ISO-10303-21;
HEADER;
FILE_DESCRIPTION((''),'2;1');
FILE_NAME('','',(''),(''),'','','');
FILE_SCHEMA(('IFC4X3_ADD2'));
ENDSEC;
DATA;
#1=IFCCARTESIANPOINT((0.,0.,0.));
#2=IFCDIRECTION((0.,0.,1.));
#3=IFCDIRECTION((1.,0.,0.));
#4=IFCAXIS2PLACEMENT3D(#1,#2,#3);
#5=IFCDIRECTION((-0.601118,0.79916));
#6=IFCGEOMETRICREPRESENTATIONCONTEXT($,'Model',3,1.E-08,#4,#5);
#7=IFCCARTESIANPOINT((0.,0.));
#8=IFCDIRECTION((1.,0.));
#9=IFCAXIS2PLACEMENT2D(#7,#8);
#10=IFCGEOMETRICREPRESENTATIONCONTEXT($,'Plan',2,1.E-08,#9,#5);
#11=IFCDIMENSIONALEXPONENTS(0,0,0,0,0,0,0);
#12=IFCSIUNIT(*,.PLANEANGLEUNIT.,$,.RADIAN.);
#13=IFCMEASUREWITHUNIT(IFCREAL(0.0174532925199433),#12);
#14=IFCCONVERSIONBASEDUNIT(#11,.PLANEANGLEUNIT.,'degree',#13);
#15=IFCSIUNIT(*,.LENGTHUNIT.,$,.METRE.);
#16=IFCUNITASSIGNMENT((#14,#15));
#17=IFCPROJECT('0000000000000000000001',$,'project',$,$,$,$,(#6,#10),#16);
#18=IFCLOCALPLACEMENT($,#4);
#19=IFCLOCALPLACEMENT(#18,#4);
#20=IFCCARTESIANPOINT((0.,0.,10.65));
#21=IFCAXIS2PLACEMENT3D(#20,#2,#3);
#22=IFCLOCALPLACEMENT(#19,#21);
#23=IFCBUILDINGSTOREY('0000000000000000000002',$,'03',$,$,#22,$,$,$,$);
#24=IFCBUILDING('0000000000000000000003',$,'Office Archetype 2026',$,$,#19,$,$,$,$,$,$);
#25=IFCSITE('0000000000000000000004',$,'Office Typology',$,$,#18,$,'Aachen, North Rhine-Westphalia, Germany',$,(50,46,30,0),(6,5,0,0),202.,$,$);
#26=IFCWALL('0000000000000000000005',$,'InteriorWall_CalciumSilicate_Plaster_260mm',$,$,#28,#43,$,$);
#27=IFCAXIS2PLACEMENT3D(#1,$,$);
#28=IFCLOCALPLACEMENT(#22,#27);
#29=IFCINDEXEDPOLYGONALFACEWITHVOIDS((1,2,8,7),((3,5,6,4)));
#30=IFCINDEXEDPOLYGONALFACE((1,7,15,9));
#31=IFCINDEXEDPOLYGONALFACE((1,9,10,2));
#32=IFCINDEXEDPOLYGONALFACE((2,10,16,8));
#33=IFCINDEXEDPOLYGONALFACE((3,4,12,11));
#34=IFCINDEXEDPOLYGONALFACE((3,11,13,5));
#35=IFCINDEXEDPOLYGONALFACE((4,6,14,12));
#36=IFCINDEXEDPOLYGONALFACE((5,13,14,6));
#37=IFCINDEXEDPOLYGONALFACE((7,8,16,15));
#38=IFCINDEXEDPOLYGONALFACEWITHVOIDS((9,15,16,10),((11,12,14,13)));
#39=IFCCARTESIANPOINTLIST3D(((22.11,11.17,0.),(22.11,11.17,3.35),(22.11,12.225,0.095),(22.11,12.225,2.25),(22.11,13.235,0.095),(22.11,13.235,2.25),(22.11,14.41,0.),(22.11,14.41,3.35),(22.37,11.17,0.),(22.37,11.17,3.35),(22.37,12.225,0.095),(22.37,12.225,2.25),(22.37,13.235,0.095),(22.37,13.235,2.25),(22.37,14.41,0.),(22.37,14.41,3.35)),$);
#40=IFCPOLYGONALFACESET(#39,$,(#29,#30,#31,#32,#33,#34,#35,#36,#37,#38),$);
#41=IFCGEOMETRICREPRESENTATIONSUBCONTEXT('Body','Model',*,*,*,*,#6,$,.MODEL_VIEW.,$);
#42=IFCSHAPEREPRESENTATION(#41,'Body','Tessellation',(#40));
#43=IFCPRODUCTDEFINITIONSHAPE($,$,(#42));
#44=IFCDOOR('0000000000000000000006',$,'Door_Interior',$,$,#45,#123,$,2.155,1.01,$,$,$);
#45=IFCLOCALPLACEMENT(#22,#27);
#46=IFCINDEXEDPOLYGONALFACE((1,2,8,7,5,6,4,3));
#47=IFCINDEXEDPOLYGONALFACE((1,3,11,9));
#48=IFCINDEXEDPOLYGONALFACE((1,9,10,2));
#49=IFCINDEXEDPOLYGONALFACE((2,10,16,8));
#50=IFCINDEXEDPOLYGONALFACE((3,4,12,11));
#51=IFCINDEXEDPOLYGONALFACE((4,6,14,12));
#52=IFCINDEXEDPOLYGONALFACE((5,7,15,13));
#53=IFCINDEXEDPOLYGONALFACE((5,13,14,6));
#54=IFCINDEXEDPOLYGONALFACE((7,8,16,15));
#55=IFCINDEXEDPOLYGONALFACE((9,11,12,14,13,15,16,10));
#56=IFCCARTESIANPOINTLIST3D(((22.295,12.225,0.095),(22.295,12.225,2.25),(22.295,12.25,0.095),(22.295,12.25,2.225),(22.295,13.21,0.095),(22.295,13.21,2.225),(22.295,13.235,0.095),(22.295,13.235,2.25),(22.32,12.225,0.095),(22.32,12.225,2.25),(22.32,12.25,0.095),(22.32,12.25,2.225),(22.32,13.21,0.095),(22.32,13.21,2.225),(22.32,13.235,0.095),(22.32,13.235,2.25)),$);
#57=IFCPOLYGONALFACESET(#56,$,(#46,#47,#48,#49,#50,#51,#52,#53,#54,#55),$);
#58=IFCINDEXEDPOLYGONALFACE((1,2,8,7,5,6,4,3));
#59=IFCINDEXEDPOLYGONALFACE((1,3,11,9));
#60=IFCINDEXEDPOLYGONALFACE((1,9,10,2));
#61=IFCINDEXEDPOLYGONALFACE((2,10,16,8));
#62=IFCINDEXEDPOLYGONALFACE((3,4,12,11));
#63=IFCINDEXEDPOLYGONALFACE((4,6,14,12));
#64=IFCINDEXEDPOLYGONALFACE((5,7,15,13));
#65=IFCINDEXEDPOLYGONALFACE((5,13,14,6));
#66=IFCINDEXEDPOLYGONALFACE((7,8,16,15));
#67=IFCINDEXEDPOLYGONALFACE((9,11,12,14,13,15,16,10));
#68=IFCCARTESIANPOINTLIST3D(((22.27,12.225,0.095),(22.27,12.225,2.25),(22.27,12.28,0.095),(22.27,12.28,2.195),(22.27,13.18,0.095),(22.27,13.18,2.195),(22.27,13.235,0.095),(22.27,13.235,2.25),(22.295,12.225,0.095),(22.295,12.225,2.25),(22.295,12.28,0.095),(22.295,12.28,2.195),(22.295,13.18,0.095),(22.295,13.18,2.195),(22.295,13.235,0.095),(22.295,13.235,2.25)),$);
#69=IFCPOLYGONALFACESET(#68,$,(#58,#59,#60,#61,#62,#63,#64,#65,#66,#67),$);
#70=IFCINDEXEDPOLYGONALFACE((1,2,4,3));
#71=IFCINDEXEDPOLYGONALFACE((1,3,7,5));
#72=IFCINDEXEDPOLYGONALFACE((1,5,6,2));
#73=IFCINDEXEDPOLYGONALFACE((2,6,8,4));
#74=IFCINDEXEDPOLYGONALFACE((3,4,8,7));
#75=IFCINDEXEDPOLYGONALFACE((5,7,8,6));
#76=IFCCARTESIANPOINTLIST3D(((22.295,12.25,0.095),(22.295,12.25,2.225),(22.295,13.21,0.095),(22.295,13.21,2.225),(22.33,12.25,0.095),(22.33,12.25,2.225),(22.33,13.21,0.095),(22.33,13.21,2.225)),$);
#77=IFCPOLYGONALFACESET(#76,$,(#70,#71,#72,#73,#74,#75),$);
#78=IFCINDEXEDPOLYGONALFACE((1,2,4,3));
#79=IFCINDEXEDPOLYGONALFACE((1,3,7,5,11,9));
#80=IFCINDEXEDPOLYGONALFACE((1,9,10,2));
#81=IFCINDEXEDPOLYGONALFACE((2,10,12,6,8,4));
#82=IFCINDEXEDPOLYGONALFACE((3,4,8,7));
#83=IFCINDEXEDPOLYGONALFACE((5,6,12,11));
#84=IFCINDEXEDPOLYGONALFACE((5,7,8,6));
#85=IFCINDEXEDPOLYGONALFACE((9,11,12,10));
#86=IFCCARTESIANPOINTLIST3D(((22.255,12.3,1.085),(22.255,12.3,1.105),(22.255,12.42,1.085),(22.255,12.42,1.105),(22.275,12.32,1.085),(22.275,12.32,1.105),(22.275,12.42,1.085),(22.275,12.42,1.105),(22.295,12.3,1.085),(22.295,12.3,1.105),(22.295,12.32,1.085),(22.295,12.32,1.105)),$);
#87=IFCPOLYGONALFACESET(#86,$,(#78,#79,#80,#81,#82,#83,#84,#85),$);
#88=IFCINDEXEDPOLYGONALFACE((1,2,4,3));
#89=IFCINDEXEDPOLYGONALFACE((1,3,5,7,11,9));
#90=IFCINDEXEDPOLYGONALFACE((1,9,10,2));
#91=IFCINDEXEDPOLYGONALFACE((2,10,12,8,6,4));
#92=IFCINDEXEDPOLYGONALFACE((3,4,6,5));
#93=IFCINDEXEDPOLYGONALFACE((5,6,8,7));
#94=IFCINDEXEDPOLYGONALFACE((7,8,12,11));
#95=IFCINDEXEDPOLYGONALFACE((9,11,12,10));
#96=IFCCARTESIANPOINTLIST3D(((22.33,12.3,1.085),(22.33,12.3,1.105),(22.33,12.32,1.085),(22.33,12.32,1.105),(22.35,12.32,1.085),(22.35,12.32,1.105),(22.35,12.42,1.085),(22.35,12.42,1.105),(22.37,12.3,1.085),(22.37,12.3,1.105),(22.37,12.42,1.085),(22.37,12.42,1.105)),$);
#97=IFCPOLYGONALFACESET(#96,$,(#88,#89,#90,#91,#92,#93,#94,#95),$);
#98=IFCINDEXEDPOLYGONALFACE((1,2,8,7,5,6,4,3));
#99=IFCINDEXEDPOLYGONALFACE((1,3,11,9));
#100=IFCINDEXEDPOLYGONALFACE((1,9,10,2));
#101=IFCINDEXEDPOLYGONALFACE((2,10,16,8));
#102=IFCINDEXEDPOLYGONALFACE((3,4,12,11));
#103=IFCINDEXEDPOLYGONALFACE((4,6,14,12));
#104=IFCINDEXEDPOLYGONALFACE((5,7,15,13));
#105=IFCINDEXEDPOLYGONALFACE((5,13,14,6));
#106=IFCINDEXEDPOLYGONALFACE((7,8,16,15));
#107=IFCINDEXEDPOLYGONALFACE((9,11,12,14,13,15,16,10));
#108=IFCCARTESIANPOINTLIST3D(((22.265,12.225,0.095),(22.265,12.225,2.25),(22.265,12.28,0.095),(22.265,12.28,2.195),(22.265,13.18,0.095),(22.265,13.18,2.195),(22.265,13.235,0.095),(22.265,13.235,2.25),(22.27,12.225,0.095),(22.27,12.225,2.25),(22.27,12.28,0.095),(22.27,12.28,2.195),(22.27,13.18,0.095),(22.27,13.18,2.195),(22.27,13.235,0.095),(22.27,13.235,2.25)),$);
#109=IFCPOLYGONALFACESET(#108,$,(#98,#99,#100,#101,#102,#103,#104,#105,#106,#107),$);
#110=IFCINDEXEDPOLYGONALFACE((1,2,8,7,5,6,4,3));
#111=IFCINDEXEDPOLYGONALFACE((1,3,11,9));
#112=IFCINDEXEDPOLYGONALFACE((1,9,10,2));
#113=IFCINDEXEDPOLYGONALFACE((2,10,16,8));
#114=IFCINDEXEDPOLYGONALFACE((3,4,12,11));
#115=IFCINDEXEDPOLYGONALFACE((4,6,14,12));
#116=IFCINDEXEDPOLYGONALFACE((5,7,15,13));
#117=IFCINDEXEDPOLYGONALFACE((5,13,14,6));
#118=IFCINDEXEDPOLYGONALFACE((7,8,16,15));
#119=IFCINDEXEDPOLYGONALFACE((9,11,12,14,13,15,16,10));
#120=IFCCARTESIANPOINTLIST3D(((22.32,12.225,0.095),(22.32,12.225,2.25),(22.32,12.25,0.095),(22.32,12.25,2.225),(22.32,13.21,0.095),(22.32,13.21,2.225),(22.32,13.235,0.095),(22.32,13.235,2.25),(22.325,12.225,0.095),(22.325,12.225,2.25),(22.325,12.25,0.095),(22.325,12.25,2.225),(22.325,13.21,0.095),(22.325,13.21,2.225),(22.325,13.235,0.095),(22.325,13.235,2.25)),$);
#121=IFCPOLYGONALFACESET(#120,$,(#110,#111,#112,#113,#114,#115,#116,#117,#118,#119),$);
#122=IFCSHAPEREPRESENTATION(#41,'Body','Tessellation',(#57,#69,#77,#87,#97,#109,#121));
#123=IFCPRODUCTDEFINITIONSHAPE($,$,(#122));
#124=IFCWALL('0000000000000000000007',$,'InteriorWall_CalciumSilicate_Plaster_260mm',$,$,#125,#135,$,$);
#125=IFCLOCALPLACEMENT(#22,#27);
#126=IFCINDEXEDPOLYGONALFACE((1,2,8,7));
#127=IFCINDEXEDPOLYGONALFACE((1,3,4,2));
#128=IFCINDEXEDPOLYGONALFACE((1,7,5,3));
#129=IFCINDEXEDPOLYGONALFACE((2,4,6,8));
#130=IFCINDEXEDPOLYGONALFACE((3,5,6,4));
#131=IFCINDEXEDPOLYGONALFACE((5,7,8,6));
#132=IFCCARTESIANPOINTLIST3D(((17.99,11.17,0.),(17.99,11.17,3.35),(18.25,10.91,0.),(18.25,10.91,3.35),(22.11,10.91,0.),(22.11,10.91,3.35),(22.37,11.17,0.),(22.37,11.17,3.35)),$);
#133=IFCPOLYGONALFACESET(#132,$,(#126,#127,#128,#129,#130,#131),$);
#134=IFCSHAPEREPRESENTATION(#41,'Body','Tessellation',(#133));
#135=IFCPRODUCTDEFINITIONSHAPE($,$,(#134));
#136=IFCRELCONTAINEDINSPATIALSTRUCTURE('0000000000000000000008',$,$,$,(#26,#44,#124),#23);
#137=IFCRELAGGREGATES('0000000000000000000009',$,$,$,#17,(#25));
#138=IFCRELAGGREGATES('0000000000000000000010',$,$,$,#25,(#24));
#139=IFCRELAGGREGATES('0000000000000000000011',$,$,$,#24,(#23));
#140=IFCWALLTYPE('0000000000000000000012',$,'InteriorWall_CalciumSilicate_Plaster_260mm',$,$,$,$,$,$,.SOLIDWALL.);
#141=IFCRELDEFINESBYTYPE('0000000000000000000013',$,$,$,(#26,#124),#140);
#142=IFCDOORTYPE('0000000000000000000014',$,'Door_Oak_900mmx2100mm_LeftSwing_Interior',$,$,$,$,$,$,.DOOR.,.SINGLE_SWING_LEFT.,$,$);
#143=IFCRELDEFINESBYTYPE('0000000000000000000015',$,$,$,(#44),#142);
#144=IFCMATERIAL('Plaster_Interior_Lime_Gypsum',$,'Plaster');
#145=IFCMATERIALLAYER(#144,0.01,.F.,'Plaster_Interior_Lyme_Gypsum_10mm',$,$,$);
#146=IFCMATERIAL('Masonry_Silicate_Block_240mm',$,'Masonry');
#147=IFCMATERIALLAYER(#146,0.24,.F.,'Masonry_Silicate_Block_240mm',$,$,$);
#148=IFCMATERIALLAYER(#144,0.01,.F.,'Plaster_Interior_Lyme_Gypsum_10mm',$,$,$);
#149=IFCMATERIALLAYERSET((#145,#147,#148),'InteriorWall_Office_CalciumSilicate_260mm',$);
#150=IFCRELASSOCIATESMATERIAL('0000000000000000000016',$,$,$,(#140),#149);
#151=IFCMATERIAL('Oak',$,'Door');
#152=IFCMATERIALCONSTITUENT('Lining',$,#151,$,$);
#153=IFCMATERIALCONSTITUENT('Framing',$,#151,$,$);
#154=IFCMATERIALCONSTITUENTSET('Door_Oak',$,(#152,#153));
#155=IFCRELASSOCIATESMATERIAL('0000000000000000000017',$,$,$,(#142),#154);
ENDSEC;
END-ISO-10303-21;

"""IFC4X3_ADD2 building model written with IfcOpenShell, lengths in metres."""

from ifc_helpers import new_model, entity, si_unit, converted_unit, direction, frame, origin_with_axes, origin_2d_with_axis, place, context, subcontext, project, spatial, line, indexed_curve, outline, extrude, source, transform, mapped, material, layer, layer_set, constituent, constituent_set, type_object, type_shapes, element, fill, save


model = new_model("IFC4X3_ADD2")

# Units and contexts
model_context = context("Model", 3, precision=1e-08, world=origin_with_axes(), true_north=direction((-0.601118, 0.79916)))
plan_context = context("Plan", 2, precision=1e-08, world=origin_2d_with_axis(), true_north=direction((-0.601118, 0.79916)))
body_context = subcontext(model_context, "Body", "Model", "MODEL_VIEW")
ifc_project = project(units=[converted_unit("PLANEANGLEUNIT", "degree", entity("IfcReal", 0.0174532925199433), si_unit("PLANEANGLEUNIT", "RADIAN"), dimensions=[0, 0, 0, 0, 0, 0, 0]), si_unit("LENGTHUNIT", "METRE")], contexts=[model_context, plan_context])

# Site, building, storey
site_placement = place(None, origin_with_axes())
site = spatial("IfcSite", under=ifc_project, at=site_placement, Name="Office Typology", LongName="Aachen, North Rhine-Westphalia, Germany", RefLatitude=(50, 46, 30, 0), RefLongitude=(6, 5, 0, 0), RefElevation=202.0)
building_placement = place(site_placement, origin_with_axes())
building = spatial("IfcBuilding", under=site, at=building_placement, Name="Office Archetype 2026")
storey_placement = place(building_placement, frame((0.0, 0.0, 10.65), z_axis=(0.0, 0.0, 1.0), x_axis=(1.0, 0.0, 0.0)))
storey = spatial("IfcBuildingStorey", under=building, at=storey_placement, Name="03")

# Wall, opening, door
ifc_material_1 = material(Name="Plaster_Interior_Lime_Gypsum", Category="Plaster")
ifc_layer_1 = layer(ifc_material_1, 0.01, ventilated=False, Name="Plaster_Interior_Lyme_Gypsum_10mm")
ifc_material_2 = material(Name="Masonry_Silicate_Block_240mm", Category="Masonry")
ifc_layer_2 = layer(ifc_material_2, 0.24, ventilated=False, Name="Masonry_Silicate_Block_240mm")
ifc_layer_3 = layer(ifc_material_1, 0.01, ventilated=False, Name="Plaster_Interior_Lyme_Gypsum_10mm")
ifc_layer_set_1 = layer_set([ifc_layer_1, ifc_layer_2, ifc_layer_3], Name="InteriorWall_Office_CalciumSilicate_260mm")
wall_type_1 = type_object("IfcWallType", Name="InteriorWall_CalciumSilicate_Plaster_260mm", PredefinedType="SOLIDWALL", material=ifc_layer_set_1)
wall_1_placement = place(storey_placement, frame((22.37, 11.17, 0.0), z_axis=(0.0, 0.0, 1.0), x_axis=(0.0, 1.0, 0.0)))
wall_1 = element("IfcWall", 1, at=wall_1_placement, inside=storey, type_object=wall_type_1, Name="InteriorWall_CalciumSilicate_Plaster_260mm", context=body_context, shape_type="SweptSolid", body=[
    extrude(outline(indexed_curve([(0.0, 0.0), (0.0, 0.26), (3.24, 0.26), (3.24, 0.0)], segments=[line(1, 2, 3, 4, 1)])), origin_with_axes(), (0.0, 0.0, 1.0), 3.35),
])
shared_shape_1 = source(origin_with_axes(), body_context, "Body", "SweptSolid", [
    extrude(outline(indexed_curve([(0.0, 2.155), (1.01, 2.155), (1.01, 0.0), (0.0, 0.0), (0.0, 2.155)])), frame((0.0, -0.015, 0.0), z_axis=(0.0, -1.0, 0.0), x_axis=(1.0, 0.0, 0.0)), (0.0, 0.0, -1.0), 0.26),
])
opening_1_placement = place(wall_1_placement, frame((2.065, 0.245, 0.095), z_axis=(0.0, 0.0, 1.0), x_axis=(-1.0, 0.0, 0.0)))
opening_1 = element("IfcOpeningElement", 2, at=opening_1_placement, cuts=wall_1, PredefinedType="OPENING", context=body_context, shape_type="MappedRepresentation", body=[
    mapped(shared_shape_1, transform((0.0, 0.0, 0.0), x_axis=(1.0, 0.0, 0.0), y_axis=(0.0, 1.0, 0.0), z_axis=(0.0, 0.0, 1.0), scale=1.0)),
])
ifc_material_3 = material(Name="Oak", Category="Door")
ifc_constituent_1 = constituent(ifc_material_3, Name="Lining")
ifc_constituent_2 = constituent(ifc_material_3, Name="Framing")
ifc_constituent_set_1 = constituent_set(constituents=[ifc_constituent_1, ifc_constituent_2], Name="Door_Oak")
door_type = type_object("IfcDoorType", Name="Door_Oak_900mmx2100mm_LeftSwing_Interior", OperationType="SINGLE_SWING_LEFT", PredefinedType="DOOR", material=ifc_constituent_set_1)
shared_shape_2 = source(origin_with_axes(), body_context, "Body", "SweptSolid", [
    extrude(outline(indexed_curve([(0.0, 0.0), (0.0, 2.155), (1.01, 2.155), (1.01, 0.0), (0.985, 0.0), (0.985, 2.13), (0.025, 2.13), (0.025, 0.0)], segments=[line(1, 2, 3, 4, 5, 6, 7, 8, 1)])), frame((0.0, 0.025, 0.0), z_axis=(0.0, -1.0, 0.0), x_axis=(1.0, 0.0, 0.0)), (0.0, 0.0, -1.0), 0.025),
    extrude(outline(indexed_curve([(0.0, 0.0), (0.0, 2.155), (1.01, 2.155), (1.01, 0.0), (0.955, 0.0), (0.955, 2.1), (0.055, 2.1), (0.055, 0.0)], segments=[line(1, 2, 3, 4, 5, 6, 7, 8, 1)])), frame((0.0, 0.0, 0.0), z_axis=(0.0, -1.0, 0.0), x_axis=(1.0, 0.0, 0.0)), (0.0, 0.0, -1.0), 0.025),
    extrude(outline(indexed_curve([(0.0, 0.0), (0.96, 0.0), (0.96, 0.035), (0.0, 0.035)], segments=[line(1, 2, 3, 4, 1)])), frame((0.025, 0.025, 0.0), z_axis=(0.0, 0.0, 1.0), x_axis=(1.0, 0.0, 0.0)), (0.0, 0.0, 1.0), 2.13),
    extrude(outline(indexed_curve([(0.0, 0.0), (0.0, -0.04), (-0.12, -0.04), (-0.12, -0.02), (-0.02, -0.02), (-0.02, 0.0)], segments=[line(1, 2, 3, 4, 5, 6, 1)])), frame((0.935, 0.025, 0.99), z_axis=(0.0, 0.0, 1.0), x_axis=(1.0, 0.0, 0.0)), (0.0, 0.0, 1.0), 0.02),
    extrude(outline(indexed_curve([(0.0, 0.0), (0.0, 0.04), (-0.12, 0.04), (-0.12, 0.02), (-0.02, 0.02), (-0.02, 0.0)], segments=[line(1, 2, 3, 4, 5, 6, 1)])), frame((0.935, 0.06, 0.99), z_axis=(0.0, 0.0, 1.0), x_axis=(1.0, 0.0, 0.0)), (0.0, 0.0, 1.0), 0.02),
    extrude(outline(indexed_curve([(0.0, 0.0), (0.0, 2.155), (1.01, 2.155), (1.01, 0.0), (0.955, 0.0), (0.955, 2.1), (0.055, 2.1), (0.055, 0.0)], segments=[line(1, 2, 3, 4, 5, 6, 7, 8, 1)])), frame((0.0, -0.005, 0.0), z_axis=(0.0, -1.0, 0.0), x_axis=(1.0, 0.0, 0.0)), (0.0, 0.0, -1.0), 0.005),
    extrude(outline(indexed_curve([(0.0, 0.0), (0.0, 2.155), (1.01, 2.155), (1.01, 0.0), (0.985, 0.0), (0.985, 2.13), (0.025, 2.13), (0.025, 0.0)], segments=[line(1, 2, 3, 4, 5, 6, 7, 8, 1)])), frame((0.0, 0.05, 0.0), z_axis=(0.0, -1.0, 0.0), x_axis=(1.0, 0.0, 0.0)), (0.0, 0.0, -1.0), 0.005),
])
type_shapes(door_type, [shared_shape_2])
door_placement = place(opening_1_placement, frame((0.0, 0.145, 0.0), z_axis=(0.0, 0.0, 1.0), x_axis=(1.0, 0.0, 0.0)))
door = element("IfcDoor", 3, at=door_placement, inside=storey, type_object=door_type, Name="Door_Interior", OverallHeight=2.155, OverallWidth=1.01, context=body_context, shape_type="MappedRepresentation", body=[
    mapped(shared_shape_2, transform((0.0, 0.0, 0.0), x_axis=(1.0, 0.0, 0.0), y_axis=(0.0, 1.0, 0.0), z_axis=(0.0, 0.0, 1.0), scale=1.0)),
])
fill(opening_1, door)

# Wall
wall_2_placement = place(storey_placement, frame((22.37, 11.17, 0.0), z_axis=(0.0, 0.0, 1.0), x_axis=(-1.0, 0.0, 0.0)))
element("IfcWall", 4, at=wall_2_placement, inside=storey, type_object=wall_type_1, Name="InteriorWall_CalciumSilicate_Plaster_260mm", context=body_context, shape_type="SweptSolid", body=[
    extrude(outline(indexed_curve([(0.0, 0.0), (0.26, 0.26), (4.12, 0.26), (4.38, 0.0)], segments=[line(1, 2, 3, 4, 1)])), origin_with_axes(), (0.0, 0.0, 1.0), 3.35),
])

save(model, "model.ifc")
